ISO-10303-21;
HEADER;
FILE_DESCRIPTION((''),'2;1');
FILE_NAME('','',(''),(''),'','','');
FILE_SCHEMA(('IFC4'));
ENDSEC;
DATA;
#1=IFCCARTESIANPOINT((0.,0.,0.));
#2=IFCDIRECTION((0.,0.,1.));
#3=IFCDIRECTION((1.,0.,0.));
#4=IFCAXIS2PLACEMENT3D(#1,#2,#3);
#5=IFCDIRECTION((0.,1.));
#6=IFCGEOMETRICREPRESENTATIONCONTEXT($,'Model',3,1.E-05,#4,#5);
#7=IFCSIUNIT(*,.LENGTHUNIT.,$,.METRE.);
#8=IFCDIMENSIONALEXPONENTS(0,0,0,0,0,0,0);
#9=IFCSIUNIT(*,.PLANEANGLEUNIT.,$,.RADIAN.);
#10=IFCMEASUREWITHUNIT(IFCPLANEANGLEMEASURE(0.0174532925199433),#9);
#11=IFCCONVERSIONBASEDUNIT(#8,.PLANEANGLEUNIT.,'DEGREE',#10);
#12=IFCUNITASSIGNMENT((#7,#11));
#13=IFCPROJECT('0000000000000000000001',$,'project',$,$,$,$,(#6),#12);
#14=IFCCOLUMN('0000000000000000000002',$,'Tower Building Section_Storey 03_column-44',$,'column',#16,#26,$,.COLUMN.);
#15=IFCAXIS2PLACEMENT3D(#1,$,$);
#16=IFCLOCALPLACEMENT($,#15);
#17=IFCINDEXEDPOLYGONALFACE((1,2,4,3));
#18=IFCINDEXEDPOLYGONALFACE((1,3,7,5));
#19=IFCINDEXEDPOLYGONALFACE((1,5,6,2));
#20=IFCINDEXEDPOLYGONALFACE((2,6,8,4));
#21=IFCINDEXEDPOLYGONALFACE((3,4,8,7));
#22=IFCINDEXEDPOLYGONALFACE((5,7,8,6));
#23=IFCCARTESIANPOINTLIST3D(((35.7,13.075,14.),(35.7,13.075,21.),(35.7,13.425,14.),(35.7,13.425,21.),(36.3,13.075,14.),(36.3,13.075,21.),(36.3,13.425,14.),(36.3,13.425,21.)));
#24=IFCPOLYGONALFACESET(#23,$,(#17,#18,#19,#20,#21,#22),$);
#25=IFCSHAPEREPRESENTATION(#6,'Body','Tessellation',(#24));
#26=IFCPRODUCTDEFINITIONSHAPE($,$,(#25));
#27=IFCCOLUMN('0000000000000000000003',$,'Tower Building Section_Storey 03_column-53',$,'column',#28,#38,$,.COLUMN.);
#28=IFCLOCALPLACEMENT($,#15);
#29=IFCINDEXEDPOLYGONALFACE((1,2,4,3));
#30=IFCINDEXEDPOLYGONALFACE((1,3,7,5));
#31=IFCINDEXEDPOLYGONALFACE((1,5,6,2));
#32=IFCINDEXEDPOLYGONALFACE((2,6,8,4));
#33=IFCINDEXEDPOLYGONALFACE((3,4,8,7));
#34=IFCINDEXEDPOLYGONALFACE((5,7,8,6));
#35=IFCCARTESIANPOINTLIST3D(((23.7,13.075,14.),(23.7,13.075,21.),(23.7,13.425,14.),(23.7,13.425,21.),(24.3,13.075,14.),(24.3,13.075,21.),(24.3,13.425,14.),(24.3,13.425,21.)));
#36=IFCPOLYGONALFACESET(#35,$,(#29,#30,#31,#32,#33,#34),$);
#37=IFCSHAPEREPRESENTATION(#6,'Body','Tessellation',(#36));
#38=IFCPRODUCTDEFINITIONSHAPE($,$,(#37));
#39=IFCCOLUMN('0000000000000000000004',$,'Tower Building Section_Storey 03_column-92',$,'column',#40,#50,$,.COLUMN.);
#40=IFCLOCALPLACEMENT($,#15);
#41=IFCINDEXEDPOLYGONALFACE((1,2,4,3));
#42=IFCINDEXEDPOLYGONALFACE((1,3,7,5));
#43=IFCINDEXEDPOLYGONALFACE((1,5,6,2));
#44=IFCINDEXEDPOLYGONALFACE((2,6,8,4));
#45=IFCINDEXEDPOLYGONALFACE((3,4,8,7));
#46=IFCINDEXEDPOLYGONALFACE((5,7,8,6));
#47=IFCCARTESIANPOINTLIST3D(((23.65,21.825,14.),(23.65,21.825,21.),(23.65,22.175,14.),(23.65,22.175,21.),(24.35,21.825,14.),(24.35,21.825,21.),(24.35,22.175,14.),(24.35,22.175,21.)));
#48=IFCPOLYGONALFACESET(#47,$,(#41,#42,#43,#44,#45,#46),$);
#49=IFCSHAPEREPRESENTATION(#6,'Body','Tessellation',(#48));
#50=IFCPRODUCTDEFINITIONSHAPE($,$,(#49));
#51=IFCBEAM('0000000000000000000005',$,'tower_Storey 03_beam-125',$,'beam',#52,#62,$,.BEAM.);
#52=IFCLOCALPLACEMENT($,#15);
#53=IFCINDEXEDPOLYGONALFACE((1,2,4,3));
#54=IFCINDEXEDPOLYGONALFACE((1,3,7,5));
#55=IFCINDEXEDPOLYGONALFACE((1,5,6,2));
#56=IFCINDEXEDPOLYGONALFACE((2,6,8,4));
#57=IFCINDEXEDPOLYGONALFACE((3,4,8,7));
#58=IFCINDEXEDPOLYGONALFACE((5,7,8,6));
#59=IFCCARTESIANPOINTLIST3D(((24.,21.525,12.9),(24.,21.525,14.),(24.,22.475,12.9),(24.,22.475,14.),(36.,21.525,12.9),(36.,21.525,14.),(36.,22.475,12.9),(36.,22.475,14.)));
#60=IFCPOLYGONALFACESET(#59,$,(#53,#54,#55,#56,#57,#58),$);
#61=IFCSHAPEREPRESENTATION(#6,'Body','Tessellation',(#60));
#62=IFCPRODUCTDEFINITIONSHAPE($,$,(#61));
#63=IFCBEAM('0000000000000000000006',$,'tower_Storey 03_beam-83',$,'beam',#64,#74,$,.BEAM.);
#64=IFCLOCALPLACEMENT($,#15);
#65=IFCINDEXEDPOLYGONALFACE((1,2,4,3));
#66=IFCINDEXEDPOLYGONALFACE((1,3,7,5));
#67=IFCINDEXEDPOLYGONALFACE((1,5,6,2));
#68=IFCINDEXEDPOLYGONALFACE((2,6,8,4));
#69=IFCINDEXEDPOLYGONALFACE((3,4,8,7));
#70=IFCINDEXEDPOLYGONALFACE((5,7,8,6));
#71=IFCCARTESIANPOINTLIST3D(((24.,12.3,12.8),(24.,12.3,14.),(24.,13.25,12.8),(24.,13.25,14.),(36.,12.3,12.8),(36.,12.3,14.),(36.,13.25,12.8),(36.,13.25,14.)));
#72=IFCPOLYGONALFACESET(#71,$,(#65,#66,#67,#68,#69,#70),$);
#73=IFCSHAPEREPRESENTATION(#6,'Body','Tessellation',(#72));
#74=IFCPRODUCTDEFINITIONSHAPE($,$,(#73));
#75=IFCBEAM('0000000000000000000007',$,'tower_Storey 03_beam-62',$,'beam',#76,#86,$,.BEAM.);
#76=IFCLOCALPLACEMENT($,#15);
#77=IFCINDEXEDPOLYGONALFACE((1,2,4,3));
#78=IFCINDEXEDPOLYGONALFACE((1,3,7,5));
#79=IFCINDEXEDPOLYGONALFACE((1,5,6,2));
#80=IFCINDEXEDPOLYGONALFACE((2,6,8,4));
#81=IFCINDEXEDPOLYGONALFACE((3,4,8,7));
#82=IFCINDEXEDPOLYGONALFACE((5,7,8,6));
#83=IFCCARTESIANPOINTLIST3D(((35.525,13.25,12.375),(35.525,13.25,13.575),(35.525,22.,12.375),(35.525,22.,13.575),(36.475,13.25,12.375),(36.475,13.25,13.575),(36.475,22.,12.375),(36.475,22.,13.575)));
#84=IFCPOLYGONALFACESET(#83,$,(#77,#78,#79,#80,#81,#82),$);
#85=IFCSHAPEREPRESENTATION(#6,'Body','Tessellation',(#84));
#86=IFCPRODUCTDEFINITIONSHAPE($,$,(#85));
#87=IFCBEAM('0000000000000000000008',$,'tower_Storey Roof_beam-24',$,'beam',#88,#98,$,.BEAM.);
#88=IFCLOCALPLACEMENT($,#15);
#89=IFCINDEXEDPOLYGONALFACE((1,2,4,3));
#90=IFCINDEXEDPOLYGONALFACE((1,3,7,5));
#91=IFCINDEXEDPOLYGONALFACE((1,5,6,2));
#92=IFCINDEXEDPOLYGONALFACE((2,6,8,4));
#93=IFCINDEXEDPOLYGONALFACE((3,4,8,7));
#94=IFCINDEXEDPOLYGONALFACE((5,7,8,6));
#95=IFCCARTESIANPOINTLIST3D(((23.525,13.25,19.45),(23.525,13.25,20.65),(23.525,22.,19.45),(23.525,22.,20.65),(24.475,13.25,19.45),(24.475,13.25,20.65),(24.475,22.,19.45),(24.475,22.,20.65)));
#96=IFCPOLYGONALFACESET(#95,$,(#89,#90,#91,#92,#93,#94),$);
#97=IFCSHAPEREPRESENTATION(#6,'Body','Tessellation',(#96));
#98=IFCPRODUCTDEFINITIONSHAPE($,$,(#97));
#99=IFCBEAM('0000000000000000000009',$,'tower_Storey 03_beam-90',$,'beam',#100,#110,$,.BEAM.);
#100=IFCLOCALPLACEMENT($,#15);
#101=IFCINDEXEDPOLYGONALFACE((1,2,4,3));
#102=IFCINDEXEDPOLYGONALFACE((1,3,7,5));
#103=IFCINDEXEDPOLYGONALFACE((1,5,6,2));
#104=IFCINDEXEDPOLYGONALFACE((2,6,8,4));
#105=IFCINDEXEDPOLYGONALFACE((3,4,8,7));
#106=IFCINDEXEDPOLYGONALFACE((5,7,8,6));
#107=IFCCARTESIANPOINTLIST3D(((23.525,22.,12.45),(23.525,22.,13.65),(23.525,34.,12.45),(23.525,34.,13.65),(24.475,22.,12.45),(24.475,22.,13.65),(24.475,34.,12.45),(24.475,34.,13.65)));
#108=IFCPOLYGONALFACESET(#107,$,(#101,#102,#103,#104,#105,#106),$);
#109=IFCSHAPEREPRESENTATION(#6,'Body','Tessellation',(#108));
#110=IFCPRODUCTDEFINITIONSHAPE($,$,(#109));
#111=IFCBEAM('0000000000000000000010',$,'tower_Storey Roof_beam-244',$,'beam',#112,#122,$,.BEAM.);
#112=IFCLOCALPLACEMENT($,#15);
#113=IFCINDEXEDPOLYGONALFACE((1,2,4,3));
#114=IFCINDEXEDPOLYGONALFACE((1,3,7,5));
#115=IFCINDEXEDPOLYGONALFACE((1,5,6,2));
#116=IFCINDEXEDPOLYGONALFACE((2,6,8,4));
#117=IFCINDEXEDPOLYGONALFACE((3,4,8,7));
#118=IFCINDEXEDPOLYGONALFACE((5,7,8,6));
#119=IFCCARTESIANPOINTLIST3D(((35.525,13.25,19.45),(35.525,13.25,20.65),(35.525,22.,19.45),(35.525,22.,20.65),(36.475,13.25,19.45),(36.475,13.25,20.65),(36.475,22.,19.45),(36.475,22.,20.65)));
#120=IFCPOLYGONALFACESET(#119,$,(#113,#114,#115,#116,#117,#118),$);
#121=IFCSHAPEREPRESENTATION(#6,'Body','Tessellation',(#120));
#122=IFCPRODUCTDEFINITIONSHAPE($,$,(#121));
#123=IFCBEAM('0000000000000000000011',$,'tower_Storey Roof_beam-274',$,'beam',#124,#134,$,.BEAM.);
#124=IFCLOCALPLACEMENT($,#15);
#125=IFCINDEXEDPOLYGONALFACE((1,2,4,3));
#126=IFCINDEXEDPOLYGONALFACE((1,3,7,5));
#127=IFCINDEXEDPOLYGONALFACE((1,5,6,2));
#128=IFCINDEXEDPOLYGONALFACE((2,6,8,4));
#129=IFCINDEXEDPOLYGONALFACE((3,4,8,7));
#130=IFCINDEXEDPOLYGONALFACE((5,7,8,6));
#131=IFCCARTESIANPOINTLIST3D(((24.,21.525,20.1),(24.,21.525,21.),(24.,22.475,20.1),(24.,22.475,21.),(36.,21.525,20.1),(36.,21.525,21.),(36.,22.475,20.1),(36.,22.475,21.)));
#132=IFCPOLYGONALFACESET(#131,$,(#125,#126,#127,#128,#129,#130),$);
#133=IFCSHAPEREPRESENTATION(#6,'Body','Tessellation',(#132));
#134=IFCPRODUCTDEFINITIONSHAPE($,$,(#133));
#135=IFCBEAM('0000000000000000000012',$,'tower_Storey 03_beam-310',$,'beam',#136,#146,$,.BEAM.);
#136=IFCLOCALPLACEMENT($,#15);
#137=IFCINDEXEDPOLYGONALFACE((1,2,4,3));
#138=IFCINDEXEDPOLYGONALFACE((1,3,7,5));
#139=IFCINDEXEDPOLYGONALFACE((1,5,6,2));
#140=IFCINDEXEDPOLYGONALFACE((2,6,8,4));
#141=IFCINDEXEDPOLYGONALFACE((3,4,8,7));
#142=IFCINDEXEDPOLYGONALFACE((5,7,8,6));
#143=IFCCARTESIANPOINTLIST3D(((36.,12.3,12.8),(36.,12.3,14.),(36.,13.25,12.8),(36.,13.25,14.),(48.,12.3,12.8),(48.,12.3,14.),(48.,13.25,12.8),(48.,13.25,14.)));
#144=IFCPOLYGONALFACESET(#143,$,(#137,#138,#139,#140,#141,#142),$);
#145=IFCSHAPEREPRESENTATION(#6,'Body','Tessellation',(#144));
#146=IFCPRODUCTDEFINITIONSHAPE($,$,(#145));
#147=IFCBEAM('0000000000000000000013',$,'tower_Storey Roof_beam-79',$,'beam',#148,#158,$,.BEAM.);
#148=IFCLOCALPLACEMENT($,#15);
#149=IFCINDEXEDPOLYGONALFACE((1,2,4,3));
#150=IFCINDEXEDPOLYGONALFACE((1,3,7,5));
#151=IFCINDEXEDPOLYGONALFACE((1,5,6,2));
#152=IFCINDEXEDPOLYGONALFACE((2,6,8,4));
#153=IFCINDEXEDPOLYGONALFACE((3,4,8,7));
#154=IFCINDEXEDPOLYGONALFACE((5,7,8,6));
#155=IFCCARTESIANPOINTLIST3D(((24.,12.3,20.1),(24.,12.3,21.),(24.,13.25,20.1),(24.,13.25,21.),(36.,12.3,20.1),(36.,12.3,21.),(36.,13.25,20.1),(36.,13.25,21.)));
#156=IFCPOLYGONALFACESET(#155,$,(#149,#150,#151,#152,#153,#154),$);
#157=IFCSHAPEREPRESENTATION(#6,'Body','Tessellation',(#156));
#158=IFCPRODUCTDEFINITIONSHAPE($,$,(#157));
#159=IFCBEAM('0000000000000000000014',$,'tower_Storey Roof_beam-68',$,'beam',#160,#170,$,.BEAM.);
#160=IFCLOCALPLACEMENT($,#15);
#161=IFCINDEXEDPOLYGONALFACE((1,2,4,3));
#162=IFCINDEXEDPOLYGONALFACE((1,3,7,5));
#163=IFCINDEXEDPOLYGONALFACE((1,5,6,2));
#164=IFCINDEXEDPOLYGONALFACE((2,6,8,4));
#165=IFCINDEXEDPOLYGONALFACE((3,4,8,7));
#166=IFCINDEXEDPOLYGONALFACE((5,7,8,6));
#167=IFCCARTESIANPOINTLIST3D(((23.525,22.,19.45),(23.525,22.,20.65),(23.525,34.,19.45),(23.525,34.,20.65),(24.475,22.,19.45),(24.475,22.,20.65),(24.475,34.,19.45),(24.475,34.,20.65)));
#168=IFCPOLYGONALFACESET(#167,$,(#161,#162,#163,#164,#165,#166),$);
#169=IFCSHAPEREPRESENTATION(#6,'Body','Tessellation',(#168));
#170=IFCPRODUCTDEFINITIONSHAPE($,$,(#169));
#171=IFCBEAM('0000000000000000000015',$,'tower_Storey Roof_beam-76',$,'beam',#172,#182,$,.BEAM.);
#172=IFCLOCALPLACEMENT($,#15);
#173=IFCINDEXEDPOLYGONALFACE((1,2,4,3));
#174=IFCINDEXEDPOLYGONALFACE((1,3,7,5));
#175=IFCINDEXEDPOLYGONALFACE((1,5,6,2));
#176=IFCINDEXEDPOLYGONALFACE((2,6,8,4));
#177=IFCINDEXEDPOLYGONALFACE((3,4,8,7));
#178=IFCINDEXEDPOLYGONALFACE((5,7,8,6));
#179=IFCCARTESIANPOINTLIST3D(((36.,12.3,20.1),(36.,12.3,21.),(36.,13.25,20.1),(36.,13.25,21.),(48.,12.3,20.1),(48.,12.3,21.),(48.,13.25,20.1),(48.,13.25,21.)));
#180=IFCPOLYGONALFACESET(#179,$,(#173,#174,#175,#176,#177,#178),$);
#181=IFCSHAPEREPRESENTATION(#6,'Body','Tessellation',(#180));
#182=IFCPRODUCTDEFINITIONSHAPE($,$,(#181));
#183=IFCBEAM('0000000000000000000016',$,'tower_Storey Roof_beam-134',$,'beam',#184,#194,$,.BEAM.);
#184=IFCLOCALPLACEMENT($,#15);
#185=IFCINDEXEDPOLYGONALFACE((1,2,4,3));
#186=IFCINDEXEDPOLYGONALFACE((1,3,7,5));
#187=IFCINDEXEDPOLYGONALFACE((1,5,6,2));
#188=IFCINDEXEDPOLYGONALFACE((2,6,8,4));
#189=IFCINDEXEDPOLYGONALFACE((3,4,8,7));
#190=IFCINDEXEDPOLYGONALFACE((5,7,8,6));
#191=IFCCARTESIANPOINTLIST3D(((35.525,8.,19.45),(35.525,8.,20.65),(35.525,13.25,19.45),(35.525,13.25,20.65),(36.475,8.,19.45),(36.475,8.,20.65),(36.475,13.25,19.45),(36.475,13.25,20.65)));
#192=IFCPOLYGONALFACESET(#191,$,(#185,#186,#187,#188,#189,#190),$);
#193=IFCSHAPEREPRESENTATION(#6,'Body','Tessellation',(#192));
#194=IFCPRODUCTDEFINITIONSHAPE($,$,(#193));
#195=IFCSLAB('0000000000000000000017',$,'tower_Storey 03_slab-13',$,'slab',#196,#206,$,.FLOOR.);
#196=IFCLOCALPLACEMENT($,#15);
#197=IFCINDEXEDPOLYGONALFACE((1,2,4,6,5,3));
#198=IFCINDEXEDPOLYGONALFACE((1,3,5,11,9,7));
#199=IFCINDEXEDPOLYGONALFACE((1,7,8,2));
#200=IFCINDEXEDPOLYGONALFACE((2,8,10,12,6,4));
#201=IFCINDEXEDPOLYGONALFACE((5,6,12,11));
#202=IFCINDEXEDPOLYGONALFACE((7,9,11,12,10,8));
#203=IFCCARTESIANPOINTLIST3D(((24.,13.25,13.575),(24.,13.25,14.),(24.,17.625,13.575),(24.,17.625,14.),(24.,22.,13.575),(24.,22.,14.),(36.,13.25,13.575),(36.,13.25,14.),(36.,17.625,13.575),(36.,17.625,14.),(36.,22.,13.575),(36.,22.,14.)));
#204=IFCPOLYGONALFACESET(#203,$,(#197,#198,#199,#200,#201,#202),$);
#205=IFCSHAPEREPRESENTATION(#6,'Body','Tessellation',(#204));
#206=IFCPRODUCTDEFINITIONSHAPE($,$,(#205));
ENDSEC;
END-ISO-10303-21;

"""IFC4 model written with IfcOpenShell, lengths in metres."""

from ifc_helpers import new_model, entity, si_unit, converted_unit, direction, frame, origin_with_axes, place, context, project, polyline, outline, extrude, element, save


model = new_model("IFC4")

# Units and contexts
model_context = context("Model", 3, precision=1e-05, world=origin_with_axes(), true_north=direction((0.0, 1.0)))
ifc_project = project(units=[si_unit("LENGTHUNIT", "METRE"), converted_unit("PLANEANGLEUNIT", "DEGREE", entity("IfcPlaneAngleMeasure", 0.0174532925199433), si_unit("PLANEANGLEUNIT", "RADIAN"), dimensions=[0, 0, 0, 0, 0, 0, 0])], contexts=[model_context])

# Columns
placement_1 = place(None, origin_with_axes())
placement_2 = place(placement_1, frame((0.0, 0.0, 14.0), z_axis=(0.0, 0.0, 1.0), x_axis=(1.0, 0.0, 0.0)))
for number, where, z_axis, x_axis, name in (
    (1, (36.0, 13.25, 0.0), (0.0, 0.0, 1.0), (1.0, 0.0, 0.0), "Tower Building Section_Storey 03_column-44"),
    (2, (24.0, 13.25, 0.0), (0.0, 0.0, 1.0), (1.0, 0.0, 0.0), "Tower Building Section_Storey 03_column-53"),
):
    element("IfcColumn", number, at=place(placement_2, frame(where, z_axis=z_axis, x_axis=x_axis)), Name=name, ObjectType="column", PredefinedType="COLUMN", context=model_context, body=[
        extrude(outline(polyline([(-0.3, -0.175, 0.0), (0.3, -0.175, 0.0), (0.3, 0.175, 0.0), (-0.3, 0.175, 0.0), (-0.3, -0.175, 0.0)])), origin_with_axes(), (0.0, 0.0, 1.0), 7.0),
    ])
column_placement = place(placement_2, frame((24.0, 22.0, 0.0), z_axis=(0.0, 0.0, 1.0), x_axis=(1.0, 0.0, 0.0)))
element("IfcColumn", 3, at=column_placement, Name="Tower Building Section_Storey 03_column-92", ObjectType="column", PredefinedType="COLUMN", context=model_context, body=[
    extrude(outline(polyline([(-0.35, -0.175, 0.0), (0.35, -0.175, 0.0), (0.35, 0.175, 0.0), (-0.35, 0.175, 0.0), (-0.35, -0.175, 0.0)])), origin_with_axes(), (0.0, 0.0, 1.0), 7.0),
])

# Beams
beam_1_placement = place(placement_2, frame((24.0, 22.0, -0.55), z_axis=(1.0, 0.0, 0.0), x_axis=(0.0, 1.0, 0.0)))
element("IfcBeam", 4, at=beam_1_placement, Name="tower_Storey 03_beam-125", ObjectType="beam", PredefinedType="BEAM", context=model_context, body=[
    extrude(outline(polyline([(0.475, 0.55, 0.0), (-0.475, 0.55, 0.0), (-0.475, -0.55, 0.0), (0.475, -0.55, 0.0), (0.475, 0.55, 0.0)])), origin_with_axes(), (0.0, 0.0, 1.0), 12.0),
])
beam_2_placement = place(placement_2, frame((24.0, 12.775, -0.6), z_axis=(1.0, 0.0, 0.0), x_axis=(0.0, 1.0, 0.0)))
element("IfcBeam", 5, at=beam_2_placement, Name="tower_Storey 03_beam-83", ObjectType="beam", PredefinedType="BEAM", context=model_context, body=[
    extrude(outline(polyline([(0.475, 0.6, 0.0), (-0.475, 0.6, 0.0), (-0.475, -0.6, 0.0), (0.475, -0.6, 0.0), (0.475, 0.6, 0.0)])), origin_with_axes(), (0.0, 0.0, 1.0), 12.0),
])
beam_3_placement = place(placement_2, frame((36.0, 13.25, -1.025), z_axis=(0.0, 1.0, 0.0), x_axis=(-1.0, 0.0, 0.0)))
element("IfcBeam", 6, at=beam_3_placement, Name="tower_Storey 03_beam-62", ObjectType="beam", PredefinedType="BEAM", context=model_context, body=[
    extrude(outline(polyline([(0.475, 0.6, 0.0), (-0.475, 0.6, 0.0), (-0.475, -0.6, 0.0), (0.475, -0.6, 0.0), (0.475, 0.6, 0.0)])), origin_with_axes(), (0.0, 0.0, 1.0), 8.75),
])
placement_3 = place(placement_1, frame((0.0, 0.0, 21.0), z_axis=(0.0, 0.0, 1.0), x_axis=(1.0, 0.0, 0.0)))
beam_4_placement = place(placement_3, frame((24.0, 13.25, -0.95), z_axis=(0.0, 1.0, 0.0), x_axis=(-1.0, 0.0, 0.0)))
element("IfcBeam", 7, at=beam_4_placement, Name="tower_Storey Roof_beam-24", ObjectType="beam", PredefinedType="BEAM", context=model_context, body=[
    extrude(outline(polyline([(0.475, 0.6, 0.0), (-0.475, 0.6, 0.0), (-0.475, -0.6, 0.0), (0.475, -0.6, 0.0), (0.475, 0.6, 0.0)])), origin_with_axes(), (0.0, 0.0, 1.0), 8.75),
])
beam_5_placement = place(placement_2, frame((24.0, 22.0, -0.95), z_axis=(0.0, 1.0, 0.0), x_axis=(-1.0, 0.0, 0.0)))
element("IfcBeam", 8, at=beam_5_placement, Name="tower_Storey 03_beam-90", ObjectType="beam", PredefinedType="BEAM", context=model_context, body=[
    extrude(outline(polyline([(0.475, 0.6, 0.0), (-0.475, 0.6, 0.0), (-0.475, -0.6, 0.0), (0.475, -0.6, 0.0), (0.475, 0.6, 0.0)])), origin_with_axes(), (0.0, 0.0, 1.0), 12.0),
])
beam_6_placement = place(placement_3, frame((36.0, 13.25, -0.95), z_axis=(0.0, 1.0, 0.0), x_axis=(-1.0, 0.0, 0.0)))
element("IfcBeam", 9, at=beam_6_placement, Name="tower_Storey Roof_beam-244", ObjectType="beam", PredefinedType="BEAM", context=model_context, body=[
    extrude(outline(polyline([(0.475, 0.6, 0.0), (-0.475, 0.6, 0.0), (-0.475, -0.6, 0.0), (0.475, -0.6, 0.0), (0.475, 0.6, 0.0)])), origin_with_axes(), (0.0, 0.0, 1.0), 8.75),
])
beam_7_placement = place(placement_3, frame((24.0, 22.0, -0.45), z_axis=(1.0, 0.0, 0.0), x_axis=(0.0, 1.0, 0.0)))
element("IfcBeam", 10, at=beam_7_placement, Name="tower_Storey Roof_beam-274", ObjectType="beam", PredefinedType="BEAM", context=model_context, body=[
    extrude(outline(polyline([(0.475, 0.45, 0.0), (-0.475, 0.45, 0.0), (-0.475, -0.45, 0.0), (0.475, -0.45, 0.0), (0.475, 0.45, 0.0)])), origin_with_axes(), (0.0, 0.0, 1.0), 12.0),
])
beam_8_placement = place(placement_2, frame((36.0, 12.775, -0.6), z_axis=(1.0, 0.0, 0.0), x_axis=(0.0, 1.0, 0.0)))
element("IfcBeam", 11, at=beam_8_placement, Name="tower_Storey 03_beam-310", ObjectType="beam", PredefinedType="BEAM", context=model_context, body=[
    extrude(outline(polyline([(0.475, 0.6, 0.0), (-0.475, 0.6, 0.0), (-0.475, -0.6, 0.0), (0.475, -0.6, 0.0), (0.475, 0.6, 0.0)])), origin_with_axes(), (0.0, 0.0, 1.0), 12.0),
])
beam_9_placement = place(placement_3, frame((24.0, 12.775, -0.45), z_axis=(1.0, 0.0, 0.0), x_axis=(0.0, 1.0, 0.0)))
element("IfcBeam", 12, at=beam_9_placement, Name="tower_Storey Roof_beam-79", ObjectType="beam", PredefinedType="BEAM", context=model_context, body=[
    extrude(outline(polyline([(0.475, 0.45, 0.0), (-0.475, 0.45, 0.0), (-0.475, -0.45, 0.0), (0.475, -0.45, 0.0), (0.475, 0.45, 0.0)])), origin_with_axes(), (0.0, 0.0, 1.0), 12.0),
])
beam_10_placement = place(placement_3, frame((24.0, 22.0, -0.95), z_axis=(0.0, 1.0, 0.0), x_axis=(-1.0, 0.0, 0.0)))
element("IfcBeam", 13, at=beam_10_placement, Name="tower_Storey Roof_beam-68", ObjectType="beam", PredefinedType="BEAM", context=model_context, body=[
    extrude(outline(polyline([(0.475, 0.6, 0.0), (-0.475, 0.6, 0.0), (-0.475, -0.6, 0.0), (0.475, -0.6, 0.0), (0.475, 0.6, 0.0)])), origin_with_axes(), (0.0, 0.0, 1.0), 12.0),
])
beam_11_placement = place(placement_3, frame((36.0, 12.775, -0.45), z_axis=(1.0, 0.0, 0.0), x_axis=(0.0, 1.0, 0.0)))
element("IfcBeam", 14, at=beam_11_placement, Name="tower_Storey Roof_beam-76", ObjectType="beam", PredefinedType="BEAM", context=model_context, body=[
    extrude(outline(polyline([(0.475, 0.45, 0.0), (-0.475, 0.45, 0.0), (-0.475, -0.45, 0.0), (0.475, -0.45, 0.0), (0.475, 0.45, 0.0)])), origin_with_axes(), (0.0, 0.0, 1.0), 12.0),
])
beam_12_placement = place(placement_3, frame((36.0, 8.0, -0.95), z_axis=(0.0, 1.0, 0.0), x_axis=(-1.0, 0.0, 0.0)))
element("IfcBeam", 15, at=beam_12_placement, Name="tower_Storey Roof_beam-134", ObjectType="beam", PredefinedType="BEAM", context=model_context, body=[
    extrude(outline(polyline([(0.475, 0.6, 0.0), (-0.475, 0.6, 0.0), (-0.475, -0.6, 0.0), (0.475, -0.6, 0.0), (0.475, 0.6, 0.0)])), origin_with_axes(), (0.0, 0.0, 1.0), 5.25),
])

# Slab
slab_1_placement = place(placement_2, frame((30.0, 17.625, -0.425), z_axis=(0.0, 0.0, 1.0), x_axis=(1.0, 0.0, 0.0)))
element("IfcSlab", 16, at=slab_1_placement, Name="tower_Storey 03_slab-13", ObjectType="slab", PredefinedType="FLOOR", context=model_context, body=[
    extrude(outline(polyline([(-6.0, 0.0, 0.0), (-6.0, -4.375, 0.0), (6.0, -4.375, 0.0), (6.0, 0.0, 0.0), (6.0, 4.375, 0.0), (-6.0, 4.375, 0.0), (-6.0, 0.0, 0.0)])), origin_with_axes(), (0.0, 0.0, 1.0), 0.425),
])

save(model, "model.ifc")
